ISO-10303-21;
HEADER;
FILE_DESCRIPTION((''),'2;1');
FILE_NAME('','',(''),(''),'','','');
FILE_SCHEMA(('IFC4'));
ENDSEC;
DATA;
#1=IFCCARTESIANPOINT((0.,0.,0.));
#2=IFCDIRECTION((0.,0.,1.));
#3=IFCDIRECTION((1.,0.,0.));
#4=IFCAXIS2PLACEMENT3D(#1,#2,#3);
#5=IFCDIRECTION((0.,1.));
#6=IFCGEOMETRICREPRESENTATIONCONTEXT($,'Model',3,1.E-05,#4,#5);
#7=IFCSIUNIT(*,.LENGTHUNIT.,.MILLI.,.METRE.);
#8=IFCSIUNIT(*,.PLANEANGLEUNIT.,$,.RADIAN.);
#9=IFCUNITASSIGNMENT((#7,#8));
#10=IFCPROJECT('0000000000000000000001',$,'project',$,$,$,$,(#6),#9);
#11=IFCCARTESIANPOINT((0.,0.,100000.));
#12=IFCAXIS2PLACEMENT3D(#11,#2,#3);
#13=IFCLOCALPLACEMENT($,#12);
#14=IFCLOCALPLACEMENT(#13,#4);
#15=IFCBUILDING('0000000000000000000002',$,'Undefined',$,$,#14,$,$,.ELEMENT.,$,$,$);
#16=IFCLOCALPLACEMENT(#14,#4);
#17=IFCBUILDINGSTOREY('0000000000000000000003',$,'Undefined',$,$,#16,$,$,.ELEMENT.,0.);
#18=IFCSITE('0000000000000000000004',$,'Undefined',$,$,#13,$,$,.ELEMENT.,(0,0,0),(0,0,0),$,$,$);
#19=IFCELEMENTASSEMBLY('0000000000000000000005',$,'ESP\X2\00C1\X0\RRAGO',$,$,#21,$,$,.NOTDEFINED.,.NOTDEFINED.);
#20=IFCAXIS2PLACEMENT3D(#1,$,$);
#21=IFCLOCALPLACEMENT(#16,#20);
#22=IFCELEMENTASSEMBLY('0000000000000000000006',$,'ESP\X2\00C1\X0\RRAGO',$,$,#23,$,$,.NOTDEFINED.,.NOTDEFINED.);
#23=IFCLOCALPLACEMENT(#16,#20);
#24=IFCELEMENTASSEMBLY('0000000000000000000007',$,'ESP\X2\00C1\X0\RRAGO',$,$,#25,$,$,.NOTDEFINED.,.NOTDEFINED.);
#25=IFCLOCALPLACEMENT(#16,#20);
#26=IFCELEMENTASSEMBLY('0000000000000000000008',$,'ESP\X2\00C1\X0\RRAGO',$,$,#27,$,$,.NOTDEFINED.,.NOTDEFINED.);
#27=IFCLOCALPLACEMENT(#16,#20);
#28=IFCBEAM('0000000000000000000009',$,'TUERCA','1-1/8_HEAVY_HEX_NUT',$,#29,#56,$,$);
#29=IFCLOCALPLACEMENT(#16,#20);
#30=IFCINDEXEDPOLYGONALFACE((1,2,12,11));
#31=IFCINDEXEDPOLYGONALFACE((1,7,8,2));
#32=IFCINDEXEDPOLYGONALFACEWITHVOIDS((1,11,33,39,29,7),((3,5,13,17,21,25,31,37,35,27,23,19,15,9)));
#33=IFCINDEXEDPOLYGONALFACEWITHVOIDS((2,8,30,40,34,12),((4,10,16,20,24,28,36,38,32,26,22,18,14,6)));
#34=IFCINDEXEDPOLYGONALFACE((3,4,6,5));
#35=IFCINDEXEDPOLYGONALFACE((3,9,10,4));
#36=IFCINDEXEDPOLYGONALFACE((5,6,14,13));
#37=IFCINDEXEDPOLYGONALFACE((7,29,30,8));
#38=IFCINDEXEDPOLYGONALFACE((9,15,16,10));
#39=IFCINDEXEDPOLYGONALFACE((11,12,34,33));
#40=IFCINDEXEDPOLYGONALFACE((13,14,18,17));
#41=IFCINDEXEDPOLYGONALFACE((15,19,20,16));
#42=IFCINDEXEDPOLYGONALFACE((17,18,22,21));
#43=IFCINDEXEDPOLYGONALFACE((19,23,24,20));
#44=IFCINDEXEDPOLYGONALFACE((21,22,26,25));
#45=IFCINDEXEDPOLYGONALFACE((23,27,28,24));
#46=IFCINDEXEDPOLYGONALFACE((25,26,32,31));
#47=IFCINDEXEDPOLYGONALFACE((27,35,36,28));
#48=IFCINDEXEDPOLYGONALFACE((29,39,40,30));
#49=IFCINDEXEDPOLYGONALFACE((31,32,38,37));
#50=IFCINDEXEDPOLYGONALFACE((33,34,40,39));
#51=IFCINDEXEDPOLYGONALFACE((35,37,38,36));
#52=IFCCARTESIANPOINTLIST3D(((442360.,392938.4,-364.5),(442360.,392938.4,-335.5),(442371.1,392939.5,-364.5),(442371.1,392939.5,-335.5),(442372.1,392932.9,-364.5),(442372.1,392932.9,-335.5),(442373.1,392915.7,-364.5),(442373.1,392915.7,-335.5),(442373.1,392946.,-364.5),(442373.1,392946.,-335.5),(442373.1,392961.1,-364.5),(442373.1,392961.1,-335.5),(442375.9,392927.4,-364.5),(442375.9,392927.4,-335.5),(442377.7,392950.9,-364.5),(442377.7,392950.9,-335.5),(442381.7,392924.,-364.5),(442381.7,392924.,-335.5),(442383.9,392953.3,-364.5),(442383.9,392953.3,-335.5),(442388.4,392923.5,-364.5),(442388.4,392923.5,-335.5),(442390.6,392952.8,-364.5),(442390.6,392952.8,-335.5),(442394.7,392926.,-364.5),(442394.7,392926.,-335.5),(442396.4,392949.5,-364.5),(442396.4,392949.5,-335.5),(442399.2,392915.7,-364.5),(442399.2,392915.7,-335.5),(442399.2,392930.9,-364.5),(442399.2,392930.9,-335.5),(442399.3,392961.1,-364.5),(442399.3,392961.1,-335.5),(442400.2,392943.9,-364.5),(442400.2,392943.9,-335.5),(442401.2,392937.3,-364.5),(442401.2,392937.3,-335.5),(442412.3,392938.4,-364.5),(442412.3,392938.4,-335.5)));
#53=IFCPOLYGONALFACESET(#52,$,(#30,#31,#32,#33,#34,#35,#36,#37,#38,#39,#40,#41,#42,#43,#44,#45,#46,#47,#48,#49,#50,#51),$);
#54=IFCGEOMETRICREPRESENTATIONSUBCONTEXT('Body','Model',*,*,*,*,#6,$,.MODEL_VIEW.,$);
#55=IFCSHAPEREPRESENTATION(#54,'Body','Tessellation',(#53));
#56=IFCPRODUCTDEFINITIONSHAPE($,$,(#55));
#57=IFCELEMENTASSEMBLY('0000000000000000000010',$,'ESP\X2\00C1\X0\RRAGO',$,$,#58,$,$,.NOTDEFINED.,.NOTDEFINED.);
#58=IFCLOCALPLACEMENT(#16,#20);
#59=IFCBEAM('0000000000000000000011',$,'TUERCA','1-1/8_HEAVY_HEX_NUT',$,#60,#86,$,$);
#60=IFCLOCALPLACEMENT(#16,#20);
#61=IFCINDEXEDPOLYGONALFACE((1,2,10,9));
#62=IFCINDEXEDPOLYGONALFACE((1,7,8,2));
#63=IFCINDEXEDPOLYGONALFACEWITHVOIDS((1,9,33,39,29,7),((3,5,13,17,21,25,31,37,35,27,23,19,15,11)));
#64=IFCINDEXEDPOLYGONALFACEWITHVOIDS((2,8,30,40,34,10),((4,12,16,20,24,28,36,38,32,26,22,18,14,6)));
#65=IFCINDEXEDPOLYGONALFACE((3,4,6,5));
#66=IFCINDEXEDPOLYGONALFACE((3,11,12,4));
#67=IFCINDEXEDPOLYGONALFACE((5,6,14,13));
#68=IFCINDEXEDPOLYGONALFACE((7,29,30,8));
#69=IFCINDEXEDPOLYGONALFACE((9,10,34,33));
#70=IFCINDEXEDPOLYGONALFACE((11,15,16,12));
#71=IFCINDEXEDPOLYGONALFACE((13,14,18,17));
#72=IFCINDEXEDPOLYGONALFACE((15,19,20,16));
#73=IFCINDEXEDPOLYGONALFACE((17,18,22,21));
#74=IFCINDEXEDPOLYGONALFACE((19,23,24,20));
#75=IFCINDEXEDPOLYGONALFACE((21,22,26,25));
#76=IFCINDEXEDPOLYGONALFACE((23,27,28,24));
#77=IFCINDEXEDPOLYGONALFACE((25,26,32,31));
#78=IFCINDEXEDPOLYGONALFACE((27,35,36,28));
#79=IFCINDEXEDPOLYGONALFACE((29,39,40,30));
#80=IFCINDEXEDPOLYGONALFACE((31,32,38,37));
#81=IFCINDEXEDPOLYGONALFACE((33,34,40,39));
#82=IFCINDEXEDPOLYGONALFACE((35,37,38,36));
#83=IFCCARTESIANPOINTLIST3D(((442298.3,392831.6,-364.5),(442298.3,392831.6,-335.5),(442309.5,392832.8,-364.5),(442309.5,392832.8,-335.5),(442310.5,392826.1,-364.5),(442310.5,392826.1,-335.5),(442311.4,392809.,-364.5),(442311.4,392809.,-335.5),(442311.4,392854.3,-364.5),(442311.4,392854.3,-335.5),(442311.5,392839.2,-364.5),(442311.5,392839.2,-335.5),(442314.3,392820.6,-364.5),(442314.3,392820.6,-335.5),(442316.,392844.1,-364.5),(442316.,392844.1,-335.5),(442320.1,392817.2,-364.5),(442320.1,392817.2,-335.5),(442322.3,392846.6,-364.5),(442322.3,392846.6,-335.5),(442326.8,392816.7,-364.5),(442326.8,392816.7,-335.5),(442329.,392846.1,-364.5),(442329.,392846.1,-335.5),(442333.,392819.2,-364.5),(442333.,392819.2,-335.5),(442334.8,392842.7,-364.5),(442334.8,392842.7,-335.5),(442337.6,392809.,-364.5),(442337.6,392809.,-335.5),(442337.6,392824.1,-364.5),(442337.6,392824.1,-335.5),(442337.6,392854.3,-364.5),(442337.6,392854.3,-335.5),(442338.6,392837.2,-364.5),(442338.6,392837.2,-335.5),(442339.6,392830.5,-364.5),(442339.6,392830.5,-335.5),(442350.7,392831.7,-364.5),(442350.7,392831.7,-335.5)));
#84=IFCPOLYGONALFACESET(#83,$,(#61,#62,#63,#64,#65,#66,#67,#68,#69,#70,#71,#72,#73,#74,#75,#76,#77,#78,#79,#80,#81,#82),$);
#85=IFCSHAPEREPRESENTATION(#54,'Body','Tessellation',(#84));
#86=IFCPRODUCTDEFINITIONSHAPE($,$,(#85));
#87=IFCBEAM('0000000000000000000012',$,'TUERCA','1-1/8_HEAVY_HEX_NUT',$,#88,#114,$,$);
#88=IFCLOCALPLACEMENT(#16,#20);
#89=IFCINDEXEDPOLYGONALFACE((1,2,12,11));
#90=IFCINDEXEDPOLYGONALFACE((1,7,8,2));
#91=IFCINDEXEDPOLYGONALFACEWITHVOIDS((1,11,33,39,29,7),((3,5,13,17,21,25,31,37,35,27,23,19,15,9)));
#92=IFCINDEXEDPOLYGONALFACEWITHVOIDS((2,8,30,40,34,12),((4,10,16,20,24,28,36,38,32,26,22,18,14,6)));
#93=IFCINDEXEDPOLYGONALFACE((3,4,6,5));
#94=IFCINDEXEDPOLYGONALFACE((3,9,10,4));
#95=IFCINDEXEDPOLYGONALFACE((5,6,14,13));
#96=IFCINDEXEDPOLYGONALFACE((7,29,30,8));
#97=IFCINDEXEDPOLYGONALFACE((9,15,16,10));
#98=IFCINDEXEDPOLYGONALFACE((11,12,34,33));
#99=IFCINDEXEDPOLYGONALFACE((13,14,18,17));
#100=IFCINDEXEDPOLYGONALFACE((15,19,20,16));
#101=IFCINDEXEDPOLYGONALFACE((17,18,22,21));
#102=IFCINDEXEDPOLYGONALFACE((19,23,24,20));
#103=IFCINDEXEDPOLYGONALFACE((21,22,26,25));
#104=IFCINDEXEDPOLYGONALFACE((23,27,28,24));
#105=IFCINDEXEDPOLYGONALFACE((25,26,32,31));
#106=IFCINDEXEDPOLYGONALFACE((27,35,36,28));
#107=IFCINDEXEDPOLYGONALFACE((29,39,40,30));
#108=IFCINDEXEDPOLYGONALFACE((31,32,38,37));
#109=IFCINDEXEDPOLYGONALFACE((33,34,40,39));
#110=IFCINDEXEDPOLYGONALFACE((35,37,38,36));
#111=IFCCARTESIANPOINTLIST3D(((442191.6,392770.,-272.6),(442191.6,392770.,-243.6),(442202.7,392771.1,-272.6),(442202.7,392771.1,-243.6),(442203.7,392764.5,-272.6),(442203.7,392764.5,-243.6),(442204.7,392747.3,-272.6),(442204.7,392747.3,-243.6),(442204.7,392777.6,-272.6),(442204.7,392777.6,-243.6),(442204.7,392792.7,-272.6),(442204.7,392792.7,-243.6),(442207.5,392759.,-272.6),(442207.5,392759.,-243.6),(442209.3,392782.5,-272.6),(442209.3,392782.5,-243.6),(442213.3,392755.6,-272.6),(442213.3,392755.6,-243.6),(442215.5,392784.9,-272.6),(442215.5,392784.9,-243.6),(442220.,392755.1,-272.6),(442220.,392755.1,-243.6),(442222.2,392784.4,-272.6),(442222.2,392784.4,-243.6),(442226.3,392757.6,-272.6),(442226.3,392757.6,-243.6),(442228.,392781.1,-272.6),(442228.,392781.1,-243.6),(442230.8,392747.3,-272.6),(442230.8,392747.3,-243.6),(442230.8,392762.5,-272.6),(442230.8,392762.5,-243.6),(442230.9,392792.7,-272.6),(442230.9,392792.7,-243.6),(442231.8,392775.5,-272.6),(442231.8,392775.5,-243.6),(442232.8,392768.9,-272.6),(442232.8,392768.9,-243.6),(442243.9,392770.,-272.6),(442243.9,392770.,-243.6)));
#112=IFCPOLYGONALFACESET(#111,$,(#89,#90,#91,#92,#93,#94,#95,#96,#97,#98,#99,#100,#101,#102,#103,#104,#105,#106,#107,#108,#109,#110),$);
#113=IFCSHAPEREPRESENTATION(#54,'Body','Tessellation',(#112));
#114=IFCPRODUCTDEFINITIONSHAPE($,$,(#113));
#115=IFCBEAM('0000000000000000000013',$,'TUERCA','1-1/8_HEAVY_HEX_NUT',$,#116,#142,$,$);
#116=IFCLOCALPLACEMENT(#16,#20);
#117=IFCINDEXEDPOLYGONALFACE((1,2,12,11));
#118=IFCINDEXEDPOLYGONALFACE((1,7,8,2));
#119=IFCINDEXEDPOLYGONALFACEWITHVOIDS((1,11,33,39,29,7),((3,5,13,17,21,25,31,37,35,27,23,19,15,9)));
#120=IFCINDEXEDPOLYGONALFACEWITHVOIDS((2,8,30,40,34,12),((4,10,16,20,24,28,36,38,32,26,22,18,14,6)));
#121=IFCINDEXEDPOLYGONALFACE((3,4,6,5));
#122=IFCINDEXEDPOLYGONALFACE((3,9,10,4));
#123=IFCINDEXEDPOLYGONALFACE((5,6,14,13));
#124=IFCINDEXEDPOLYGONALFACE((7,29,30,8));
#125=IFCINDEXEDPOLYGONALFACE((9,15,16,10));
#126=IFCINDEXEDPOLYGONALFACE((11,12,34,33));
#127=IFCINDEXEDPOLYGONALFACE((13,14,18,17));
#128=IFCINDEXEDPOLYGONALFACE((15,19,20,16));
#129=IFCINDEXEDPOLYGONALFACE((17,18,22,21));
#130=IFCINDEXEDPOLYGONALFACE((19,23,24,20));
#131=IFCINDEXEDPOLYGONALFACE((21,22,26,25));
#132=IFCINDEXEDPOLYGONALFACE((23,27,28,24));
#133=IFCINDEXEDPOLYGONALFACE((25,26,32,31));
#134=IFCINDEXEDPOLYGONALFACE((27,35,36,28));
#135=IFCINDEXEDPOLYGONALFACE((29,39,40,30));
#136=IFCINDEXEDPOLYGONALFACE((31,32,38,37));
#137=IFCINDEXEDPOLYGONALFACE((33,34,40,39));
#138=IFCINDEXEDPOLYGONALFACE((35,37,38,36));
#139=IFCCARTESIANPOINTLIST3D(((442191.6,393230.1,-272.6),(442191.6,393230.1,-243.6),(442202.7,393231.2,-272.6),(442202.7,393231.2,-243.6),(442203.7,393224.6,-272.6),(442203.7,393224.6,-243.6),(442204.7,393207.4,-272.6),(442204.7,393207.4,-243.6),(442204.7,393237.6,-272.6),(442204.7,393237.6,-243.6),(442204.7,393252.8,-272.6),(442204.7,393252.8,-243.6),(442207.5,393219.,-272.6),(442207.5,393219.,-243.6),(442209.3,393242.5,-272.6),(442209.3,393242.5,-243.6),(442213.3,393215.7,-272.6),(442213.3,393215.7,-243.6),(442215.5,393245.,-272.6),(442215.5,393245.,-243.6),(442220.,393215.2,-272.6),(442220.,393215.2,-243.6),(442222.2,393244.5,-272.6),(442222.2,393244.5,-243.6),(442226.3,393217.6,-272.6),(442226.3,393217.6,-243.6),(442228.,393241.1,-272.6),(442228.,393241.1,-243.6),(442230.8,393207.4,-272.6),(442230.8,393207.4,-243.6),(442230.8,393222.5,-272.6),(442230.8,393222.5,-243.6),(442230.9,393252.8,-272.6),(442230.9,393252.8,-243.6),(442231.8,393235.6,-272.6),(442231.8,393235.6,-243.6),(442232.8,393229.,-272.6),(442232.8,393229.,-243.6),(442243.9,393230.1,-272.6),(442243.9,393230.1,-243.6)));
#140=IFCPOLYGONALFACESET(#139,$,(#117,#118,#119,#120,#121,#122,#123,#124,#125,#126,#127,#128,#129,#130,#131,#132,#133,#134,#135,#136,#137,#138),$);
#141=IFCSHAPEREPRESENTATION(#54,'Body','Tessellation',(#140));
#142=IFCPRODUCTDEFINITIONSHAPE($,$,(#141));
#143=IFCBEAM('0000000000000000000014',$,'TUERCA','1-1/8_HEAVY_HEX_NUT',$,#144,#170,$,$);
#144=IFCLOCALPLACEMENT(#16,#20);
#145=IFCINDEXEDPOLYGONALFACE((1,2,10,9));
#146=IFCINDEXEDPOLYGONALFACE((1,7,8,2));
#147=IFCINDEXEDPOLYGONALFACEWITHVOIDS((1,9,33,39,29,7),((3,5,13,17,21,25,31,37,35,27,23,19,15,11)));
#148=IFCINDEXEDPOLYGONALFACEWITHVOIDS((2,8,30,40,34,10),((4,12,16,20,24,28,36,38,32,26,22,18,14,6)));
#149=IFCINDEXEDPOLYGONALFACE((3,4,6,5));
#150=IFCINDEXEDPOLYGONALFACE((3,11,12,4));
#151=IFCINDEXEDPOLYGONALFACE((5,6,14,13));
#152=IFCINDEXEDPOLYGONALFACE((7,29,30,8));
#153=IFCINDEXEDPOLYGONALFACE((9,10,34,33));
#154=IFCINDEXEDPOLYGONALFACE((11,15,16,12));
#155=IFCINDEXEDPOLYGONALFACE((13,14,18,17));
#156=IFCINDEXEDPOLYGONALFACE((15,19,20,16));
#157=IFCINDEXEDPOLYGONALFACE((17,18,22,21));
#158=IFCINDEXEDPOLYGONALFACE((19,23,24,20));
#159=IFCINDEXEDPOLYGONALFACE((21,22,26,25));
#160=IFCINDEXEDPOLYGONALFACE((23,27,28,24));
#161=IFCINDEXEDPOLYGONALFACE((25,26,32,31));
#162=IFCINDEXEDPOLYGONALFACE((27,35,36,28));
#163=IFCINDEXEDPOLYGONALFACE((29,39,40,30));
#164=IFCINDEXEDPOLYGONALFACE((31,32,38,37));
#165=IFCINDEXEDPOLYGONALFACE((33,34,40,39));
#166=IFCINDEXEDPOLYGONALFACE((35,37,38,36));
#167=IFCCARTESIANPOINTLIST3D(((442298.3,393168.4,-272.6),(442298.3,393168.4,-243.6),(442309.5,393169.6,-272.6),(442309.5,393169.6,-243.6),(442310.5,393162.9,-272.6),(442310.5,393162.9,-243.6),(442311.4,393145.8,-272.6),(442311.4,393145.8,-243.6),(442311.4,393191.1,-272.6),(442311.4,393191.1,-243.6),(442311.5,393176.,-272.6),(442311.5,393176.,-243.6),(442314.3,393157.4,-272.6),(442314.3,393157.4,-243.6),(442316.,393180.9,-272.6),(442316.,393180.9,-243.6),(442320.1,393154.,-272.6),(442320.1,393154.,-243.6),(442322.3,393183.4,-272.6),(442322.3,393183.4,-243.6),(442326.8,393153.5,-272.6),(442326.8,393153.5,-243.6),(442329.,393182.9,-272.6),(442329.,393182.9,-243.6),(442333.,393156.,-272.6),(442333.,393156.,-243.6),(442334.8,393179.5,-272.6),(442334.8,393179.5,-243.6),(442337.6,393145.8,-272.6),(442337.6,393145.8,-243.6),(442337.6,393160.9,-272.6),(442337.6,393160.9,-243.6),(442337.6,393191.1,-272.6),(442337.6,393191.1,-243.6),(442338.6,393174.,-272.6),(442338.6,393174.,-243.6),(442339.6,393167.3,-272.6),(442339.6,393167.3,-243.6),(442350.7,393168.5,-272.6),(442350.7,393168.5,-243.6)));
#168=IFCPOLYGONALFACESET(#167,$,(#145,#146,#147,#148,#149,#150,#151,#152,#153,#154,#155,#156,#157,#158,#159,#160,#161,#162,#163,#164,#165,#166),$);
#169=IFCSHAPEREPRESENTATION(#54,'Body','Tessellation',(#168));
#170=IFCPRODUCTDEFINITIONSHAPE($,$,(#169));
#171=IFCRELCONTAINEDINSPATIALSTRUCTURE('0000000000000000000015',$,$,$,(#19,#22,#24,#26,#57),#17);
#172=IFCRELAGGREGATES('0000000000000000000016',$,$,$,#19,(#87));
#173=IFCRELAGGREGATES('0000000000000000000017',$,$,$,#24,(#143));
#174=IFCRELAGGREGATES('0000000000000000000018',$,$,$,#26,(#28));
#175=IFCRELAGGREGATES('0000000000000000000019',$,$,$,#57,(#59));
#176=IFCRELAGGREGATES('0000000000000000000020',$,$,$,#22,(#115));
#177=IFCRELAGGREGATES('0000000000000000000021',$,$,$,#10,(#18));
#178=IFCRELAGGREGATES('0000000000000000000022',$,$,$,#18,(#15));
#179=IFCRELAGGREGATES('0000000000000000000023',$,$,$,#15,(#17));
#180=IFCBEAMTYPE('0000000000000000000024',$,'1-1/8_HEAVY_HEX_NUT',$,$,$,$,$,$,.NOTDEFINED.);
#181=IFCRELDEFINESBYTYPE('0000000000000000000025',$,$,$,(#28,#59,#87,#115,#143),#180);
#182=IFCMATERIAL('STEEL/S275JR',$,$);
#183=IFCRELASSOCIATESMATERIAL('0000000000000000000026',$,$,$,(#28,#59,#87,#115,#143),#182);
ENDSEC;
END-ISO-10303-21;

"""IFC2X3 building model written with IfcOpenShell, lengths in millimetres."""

from ifc_helpers import new_model, si_unit, direction, frame, origin_with_axes, place, context, subcontext, project, spatial, polyline, outline, extrude, material, type_object, element, aggregate, save


model = new_model("IFC2X3")

# Units and contexts
model_context = context("Model", 3, precision=1e-05, world=origin_with_axes(), true_north=direction((0.0, 1.0)))
body_context = subcontext(model_context, "Body", "Model", "MODEL_VIEW")
ifc_project = project(units=[si_unit("LENGTHUNIT", "METRE", prefix="MILLI"), si_unit("PLANEANGLEUNIT", "RADIAN")], contexts=[model_context])

# Site, building, storey
site_placement = place(None, frame((0.0, 0.0, 100000.0), z_axis=(0.0, 0.0, 1.0), x_axis=(1.0, 0.0, 0.0)))
site = spatial("IfcSite", under=ifc_project, at=site_placement, Name="Undefined", CompositionType="ELEMENT", RefLatitude=(0, 0, 0), RefLongitude=(0, 0, 0))
building_placement = place(site_placement, origin_with_axes())
building = spatial("IfcBuilding", under=site, at=building_placement, Name="Undefined", CompositionType="ELEMENT")
storey_placement = place(building_placement, origin_with_axes())
storey = spatial("IfcBuildingStorey", under=building, at=storey_placement, Name="Undefined", CompositionType="ELEMENT", Elevation=0.0)

# Shared definitions
ifc_material_1 = material(Name="STEEL/S275JR")

# Element assemblies, beams
assembly_1_placement = place(storey_placement, origin_with_axes())
assembly_1 = element("IfcElementAssembly", 1, at=assembly_1_placement, inside=storey, Name="ESPÁRRAGO", AssemblyPlace="NOTDEFINED", PredefinedType="NOTDEFINED")
beam_type_1 = type_object("IfcBeamType", Name="1-1/8_HEAVY_HEX_NUT", PredefinedType="NOTDEFINED")
assembly_2_placement = place(storey_placement, origin_with_axes())
assembly_2 = element("IfcElementAssembly", 2, at=assembly_2_placement, inside=storey, Name="ESPÁRRAGO", AssemblyPlace="NOTDEFINED", PredefinedType="NOTDEFINED")
assembly_3_placement = place(storey_placement, origin_with_axes())
assembly_3 = element("IfcElementAssembly", 3, at=assembly_3_placement, inside=storey, Name="ESPÁRRAGO", AssemblyPlace="NOTDEFINED", PredefinedType="NOTDEFINED")
assembly_4_placement = place(storey_placement, origin_with_axes())
assembly_4 = element("IfcElementAssembly", 4, at=assembly_4_placement, inside=storey, Name="ESPÁRRAGO", AssemblyPlace="NOTDEFINED", PredefinedType="NOTDEFINED")
beam_1_placement = place(assembly_4_placement, frame((442386.2, 392938.4, -335.5), z_axis=(0.866025, -0.5, 0.0), x_axis=(0.0, 0.0, -1.0)))
beam_1 = element("IfcBeam", 5, at=beam_1_placement, type_object=beam_type_1, material=ifc_material_1, Name="TUERCA", Description="1-1/8_HEAVY_HEX_NUT", context=body_context, shape_type="SweptSolid", body=[
    extrude(outline(polyline([(-13.1, -22.7), (-26.2, 0.0), (-13.1, 22.7), (13.1, 22.7), (26.2, 0.0), (13.1, -22.7), (-13.1, -22.7)]), holes=[polyline([(6.5, 13.6), (0.0, 15.1), (-6.5, 13.6), (-11.8, 9.4), (-14.7, 3.4), (-14.7, -3.4), (-11.8, -9.4), (-6.5, -13.6), (0.0, -15.1), (6.5, -13.6), (11.8, -9.4), (14.7, -3.4), (14.7, 3.4), (11.8, 9.4), (6.5, 13.6)])]), frame((29.0, 0.0, 0.0), z_axis=(-1.0, 0.0, 0.0), x_axis=(0.0, -1.0, 0.0)), (0.0, 0.0, 1.0), 29.0),
])
assembly_5_placement = place(storey_placement, origin_with_axes())
assembly_5 = element("IfcElementAssembly", 6, at=assembly_5_placement, inside=storey, Name="ESPÁRRAGO", AssemblyPlace="NOTDEFINED", PredefinedType="NOTDEFINED")
beam_2_placement = place(assembly_5_placement, frame((442324.5, 392831.7, -335.5), z_axis=(0.866025, -0.5, 0.0), x_axis=(0.0, 0.0, -1.0)))
beam_2 = element("IfcBeam", 7, at=beam_2_placement, type_object=beam_type_1, material=ifc_material_1, Name="TUERCA", Description="1-1/8_HEAVY_HEX_NUT", context=body_context, shape_type="SweptSolid", body=[
    extrude(outline(polyline([(-13.1, -22.7), (-26.2, 0.0), (-13.1, 22.7), (13.1, 22.7), (26.2, 0.0), (13.1, -22.7), (-13.1, -22.7)]), holes=[polyline([(6.5, 13.6), (0.0, 15.1), (-6.5, 13.6), (-11.8, 9.4), (-14.7, 3.4), (-14.7, -3.4), (-11.8, -9.4), (-6.5, -13.6), (0.0, -15.1), (6.5, -13.6), (11.8, -9.4), (14.7, -3.4), (14.7, 3.4), (11.8, 9.4), (6.5, 13.6)])]), frame((29.0, 0.0, 0.0), z_axis=(-1.0, 0.0, 0.0), x_axis=(0.0, -1.0, 0.0)), (0.0, 0.0, 1.0), 29.0),
])

# Beams
beam_3_placement = place(assembly_1_placement, frame((442217.8, 392770.0, -243.6), z_axis=(0.866025, -0.5, 0.0), x_axis=(0.0, 0.0, -1.0)))
beam_3 = element("IfcBeam", 8, at=beam_3_placement, type_object=beam_type_1, material=ifc_material_1, Name="TUERCA", Description="1-1/8_HEAVY_HEX_NUT", context=body_context, shape_type="SweptSolid", body=[
    extrude(outline(polyline([(-13.1, -22.7), (-26.2, 0.0), (-13.1, 22.7), (13.1, 22.7), (26.2, 0.0), (13.1, -22.7), (-13.1, -22.7)]), holes=[polyline([(6.5, 13.6), (0.0, 15.1), (-6.5, 13.6), (-11.8, 9.4), (-14.7, 3.4), (-14.7, -3.4), (-11.8, -9.4), (-6.5, -13.6), (0.0, -15.1), (6.5, -13.6), (11.8, -9.4), (14.7, -3.4), (14.7, 3.4), (11.8, 9.4), (6.5, 13.6)])]), frame((29.0, 0.0, 0.0), z_axis=(-1.0, 0.0, 0.0), x_axis=(0.0, -1.0, 0.0)), (0.0, 0.0, 1.0), 29.0),
])
aggregate(assembly_1, [beam_3])
beam_4_placement = place(assembly_2_placement, frame((442217.8, 393230.1, -243.6), z_axis=(0.866025, -0.5, 0.0), x_axis=(0.0, 0.0, -1.0)))
beam_4 = element("IfcBeam", 9, at=beam_4_placement, type_object=beam_type_1, material=ifc_material_1, Name="TUERCA", Description="1-1/8_HEAVY_HEX_NUT", context=body_context, shape_type="SweptSolid", body=[
    extrude(outline(polyline([(-13.1, -22.7), (-26.2, 0.0), (-13.1, 22.7), (13.1, 22.7), (26.2, 0.0), (13.1, -22.7), (-13.1, -22.7)]), holes=[polyline([(6.5, 13.6), (0.0, 15.1), (-6.5, 13.6), (-11.8, 9.4), (-14.7, 3.4), (-14.7, -3.4), (-11.8, -9.4), (-6.5, -13.6), (0.0, -15.1), (6.5, -13.6), (11.8, -9.4), (14.7, -3.4), (14.7, 3.4), (11.8, 9.4), (6.5, 13.6)])]), frame((29.0, 0.0, 0.0), z_axis=(-1.0, 0.0, 0.0), x_axis=(0.0, -1.0, 0.0)), (0.0, 0.0, 1.0), 29.0),
])
beam_5_placement = place(assembly_3_placement, frame((442324.5, 393168.4, -243.6), z_axis=(0.866025, -0.5, 0.0), x_axis=(0.0, 0.0, -1.0)))
beam_5 = element("IfcBeam", 10, at=beam_5_placement, type_object=beam_type_1, material=ifc_material_1, Name="TUERCA", Description="1-1/8_HEAVY_HEX_NUT", context=body_context, shape_type="SweptSolid", body=[
    extrude(outline(polyline([(-13.1, -22.7), (-26.2, 0.0), (-13.1, 22.7), (13.1, 22.7), (26.2, 0.0), (13.1, -22.7), (-13.1, -22.7)]), holes=[polyline([(6.5, 13.6), (0.0, 15.1), (-6.5, 13.6), (-11.8, 9.4), (-14.7, 3.4), (-14.7, -3.4), (-11.8, -9.4), (-6.5, -13.6), (0.0, -15.1), (6.5, -13.6), (11.8, -9.4), (14.7, -3.4), (14.7, 3.4), (11.8, 9.4), (6.5, 13.6)])]), frame((29.0, 0.0, 0.0), z_axis=(-1.0, 0.0, 0.0), x_axis=(0.0, -1.0, 0.0)), (0.0, 0.0, 1.0), 29.0),
])
aggregate(assembly_3, [beam_5])
aggregate(assembly_4, [beam_1])
aggregate(assembly_5, [beam_2])
aggregate(assembly_2, [beam_4])

save(model, "model.ifc")
